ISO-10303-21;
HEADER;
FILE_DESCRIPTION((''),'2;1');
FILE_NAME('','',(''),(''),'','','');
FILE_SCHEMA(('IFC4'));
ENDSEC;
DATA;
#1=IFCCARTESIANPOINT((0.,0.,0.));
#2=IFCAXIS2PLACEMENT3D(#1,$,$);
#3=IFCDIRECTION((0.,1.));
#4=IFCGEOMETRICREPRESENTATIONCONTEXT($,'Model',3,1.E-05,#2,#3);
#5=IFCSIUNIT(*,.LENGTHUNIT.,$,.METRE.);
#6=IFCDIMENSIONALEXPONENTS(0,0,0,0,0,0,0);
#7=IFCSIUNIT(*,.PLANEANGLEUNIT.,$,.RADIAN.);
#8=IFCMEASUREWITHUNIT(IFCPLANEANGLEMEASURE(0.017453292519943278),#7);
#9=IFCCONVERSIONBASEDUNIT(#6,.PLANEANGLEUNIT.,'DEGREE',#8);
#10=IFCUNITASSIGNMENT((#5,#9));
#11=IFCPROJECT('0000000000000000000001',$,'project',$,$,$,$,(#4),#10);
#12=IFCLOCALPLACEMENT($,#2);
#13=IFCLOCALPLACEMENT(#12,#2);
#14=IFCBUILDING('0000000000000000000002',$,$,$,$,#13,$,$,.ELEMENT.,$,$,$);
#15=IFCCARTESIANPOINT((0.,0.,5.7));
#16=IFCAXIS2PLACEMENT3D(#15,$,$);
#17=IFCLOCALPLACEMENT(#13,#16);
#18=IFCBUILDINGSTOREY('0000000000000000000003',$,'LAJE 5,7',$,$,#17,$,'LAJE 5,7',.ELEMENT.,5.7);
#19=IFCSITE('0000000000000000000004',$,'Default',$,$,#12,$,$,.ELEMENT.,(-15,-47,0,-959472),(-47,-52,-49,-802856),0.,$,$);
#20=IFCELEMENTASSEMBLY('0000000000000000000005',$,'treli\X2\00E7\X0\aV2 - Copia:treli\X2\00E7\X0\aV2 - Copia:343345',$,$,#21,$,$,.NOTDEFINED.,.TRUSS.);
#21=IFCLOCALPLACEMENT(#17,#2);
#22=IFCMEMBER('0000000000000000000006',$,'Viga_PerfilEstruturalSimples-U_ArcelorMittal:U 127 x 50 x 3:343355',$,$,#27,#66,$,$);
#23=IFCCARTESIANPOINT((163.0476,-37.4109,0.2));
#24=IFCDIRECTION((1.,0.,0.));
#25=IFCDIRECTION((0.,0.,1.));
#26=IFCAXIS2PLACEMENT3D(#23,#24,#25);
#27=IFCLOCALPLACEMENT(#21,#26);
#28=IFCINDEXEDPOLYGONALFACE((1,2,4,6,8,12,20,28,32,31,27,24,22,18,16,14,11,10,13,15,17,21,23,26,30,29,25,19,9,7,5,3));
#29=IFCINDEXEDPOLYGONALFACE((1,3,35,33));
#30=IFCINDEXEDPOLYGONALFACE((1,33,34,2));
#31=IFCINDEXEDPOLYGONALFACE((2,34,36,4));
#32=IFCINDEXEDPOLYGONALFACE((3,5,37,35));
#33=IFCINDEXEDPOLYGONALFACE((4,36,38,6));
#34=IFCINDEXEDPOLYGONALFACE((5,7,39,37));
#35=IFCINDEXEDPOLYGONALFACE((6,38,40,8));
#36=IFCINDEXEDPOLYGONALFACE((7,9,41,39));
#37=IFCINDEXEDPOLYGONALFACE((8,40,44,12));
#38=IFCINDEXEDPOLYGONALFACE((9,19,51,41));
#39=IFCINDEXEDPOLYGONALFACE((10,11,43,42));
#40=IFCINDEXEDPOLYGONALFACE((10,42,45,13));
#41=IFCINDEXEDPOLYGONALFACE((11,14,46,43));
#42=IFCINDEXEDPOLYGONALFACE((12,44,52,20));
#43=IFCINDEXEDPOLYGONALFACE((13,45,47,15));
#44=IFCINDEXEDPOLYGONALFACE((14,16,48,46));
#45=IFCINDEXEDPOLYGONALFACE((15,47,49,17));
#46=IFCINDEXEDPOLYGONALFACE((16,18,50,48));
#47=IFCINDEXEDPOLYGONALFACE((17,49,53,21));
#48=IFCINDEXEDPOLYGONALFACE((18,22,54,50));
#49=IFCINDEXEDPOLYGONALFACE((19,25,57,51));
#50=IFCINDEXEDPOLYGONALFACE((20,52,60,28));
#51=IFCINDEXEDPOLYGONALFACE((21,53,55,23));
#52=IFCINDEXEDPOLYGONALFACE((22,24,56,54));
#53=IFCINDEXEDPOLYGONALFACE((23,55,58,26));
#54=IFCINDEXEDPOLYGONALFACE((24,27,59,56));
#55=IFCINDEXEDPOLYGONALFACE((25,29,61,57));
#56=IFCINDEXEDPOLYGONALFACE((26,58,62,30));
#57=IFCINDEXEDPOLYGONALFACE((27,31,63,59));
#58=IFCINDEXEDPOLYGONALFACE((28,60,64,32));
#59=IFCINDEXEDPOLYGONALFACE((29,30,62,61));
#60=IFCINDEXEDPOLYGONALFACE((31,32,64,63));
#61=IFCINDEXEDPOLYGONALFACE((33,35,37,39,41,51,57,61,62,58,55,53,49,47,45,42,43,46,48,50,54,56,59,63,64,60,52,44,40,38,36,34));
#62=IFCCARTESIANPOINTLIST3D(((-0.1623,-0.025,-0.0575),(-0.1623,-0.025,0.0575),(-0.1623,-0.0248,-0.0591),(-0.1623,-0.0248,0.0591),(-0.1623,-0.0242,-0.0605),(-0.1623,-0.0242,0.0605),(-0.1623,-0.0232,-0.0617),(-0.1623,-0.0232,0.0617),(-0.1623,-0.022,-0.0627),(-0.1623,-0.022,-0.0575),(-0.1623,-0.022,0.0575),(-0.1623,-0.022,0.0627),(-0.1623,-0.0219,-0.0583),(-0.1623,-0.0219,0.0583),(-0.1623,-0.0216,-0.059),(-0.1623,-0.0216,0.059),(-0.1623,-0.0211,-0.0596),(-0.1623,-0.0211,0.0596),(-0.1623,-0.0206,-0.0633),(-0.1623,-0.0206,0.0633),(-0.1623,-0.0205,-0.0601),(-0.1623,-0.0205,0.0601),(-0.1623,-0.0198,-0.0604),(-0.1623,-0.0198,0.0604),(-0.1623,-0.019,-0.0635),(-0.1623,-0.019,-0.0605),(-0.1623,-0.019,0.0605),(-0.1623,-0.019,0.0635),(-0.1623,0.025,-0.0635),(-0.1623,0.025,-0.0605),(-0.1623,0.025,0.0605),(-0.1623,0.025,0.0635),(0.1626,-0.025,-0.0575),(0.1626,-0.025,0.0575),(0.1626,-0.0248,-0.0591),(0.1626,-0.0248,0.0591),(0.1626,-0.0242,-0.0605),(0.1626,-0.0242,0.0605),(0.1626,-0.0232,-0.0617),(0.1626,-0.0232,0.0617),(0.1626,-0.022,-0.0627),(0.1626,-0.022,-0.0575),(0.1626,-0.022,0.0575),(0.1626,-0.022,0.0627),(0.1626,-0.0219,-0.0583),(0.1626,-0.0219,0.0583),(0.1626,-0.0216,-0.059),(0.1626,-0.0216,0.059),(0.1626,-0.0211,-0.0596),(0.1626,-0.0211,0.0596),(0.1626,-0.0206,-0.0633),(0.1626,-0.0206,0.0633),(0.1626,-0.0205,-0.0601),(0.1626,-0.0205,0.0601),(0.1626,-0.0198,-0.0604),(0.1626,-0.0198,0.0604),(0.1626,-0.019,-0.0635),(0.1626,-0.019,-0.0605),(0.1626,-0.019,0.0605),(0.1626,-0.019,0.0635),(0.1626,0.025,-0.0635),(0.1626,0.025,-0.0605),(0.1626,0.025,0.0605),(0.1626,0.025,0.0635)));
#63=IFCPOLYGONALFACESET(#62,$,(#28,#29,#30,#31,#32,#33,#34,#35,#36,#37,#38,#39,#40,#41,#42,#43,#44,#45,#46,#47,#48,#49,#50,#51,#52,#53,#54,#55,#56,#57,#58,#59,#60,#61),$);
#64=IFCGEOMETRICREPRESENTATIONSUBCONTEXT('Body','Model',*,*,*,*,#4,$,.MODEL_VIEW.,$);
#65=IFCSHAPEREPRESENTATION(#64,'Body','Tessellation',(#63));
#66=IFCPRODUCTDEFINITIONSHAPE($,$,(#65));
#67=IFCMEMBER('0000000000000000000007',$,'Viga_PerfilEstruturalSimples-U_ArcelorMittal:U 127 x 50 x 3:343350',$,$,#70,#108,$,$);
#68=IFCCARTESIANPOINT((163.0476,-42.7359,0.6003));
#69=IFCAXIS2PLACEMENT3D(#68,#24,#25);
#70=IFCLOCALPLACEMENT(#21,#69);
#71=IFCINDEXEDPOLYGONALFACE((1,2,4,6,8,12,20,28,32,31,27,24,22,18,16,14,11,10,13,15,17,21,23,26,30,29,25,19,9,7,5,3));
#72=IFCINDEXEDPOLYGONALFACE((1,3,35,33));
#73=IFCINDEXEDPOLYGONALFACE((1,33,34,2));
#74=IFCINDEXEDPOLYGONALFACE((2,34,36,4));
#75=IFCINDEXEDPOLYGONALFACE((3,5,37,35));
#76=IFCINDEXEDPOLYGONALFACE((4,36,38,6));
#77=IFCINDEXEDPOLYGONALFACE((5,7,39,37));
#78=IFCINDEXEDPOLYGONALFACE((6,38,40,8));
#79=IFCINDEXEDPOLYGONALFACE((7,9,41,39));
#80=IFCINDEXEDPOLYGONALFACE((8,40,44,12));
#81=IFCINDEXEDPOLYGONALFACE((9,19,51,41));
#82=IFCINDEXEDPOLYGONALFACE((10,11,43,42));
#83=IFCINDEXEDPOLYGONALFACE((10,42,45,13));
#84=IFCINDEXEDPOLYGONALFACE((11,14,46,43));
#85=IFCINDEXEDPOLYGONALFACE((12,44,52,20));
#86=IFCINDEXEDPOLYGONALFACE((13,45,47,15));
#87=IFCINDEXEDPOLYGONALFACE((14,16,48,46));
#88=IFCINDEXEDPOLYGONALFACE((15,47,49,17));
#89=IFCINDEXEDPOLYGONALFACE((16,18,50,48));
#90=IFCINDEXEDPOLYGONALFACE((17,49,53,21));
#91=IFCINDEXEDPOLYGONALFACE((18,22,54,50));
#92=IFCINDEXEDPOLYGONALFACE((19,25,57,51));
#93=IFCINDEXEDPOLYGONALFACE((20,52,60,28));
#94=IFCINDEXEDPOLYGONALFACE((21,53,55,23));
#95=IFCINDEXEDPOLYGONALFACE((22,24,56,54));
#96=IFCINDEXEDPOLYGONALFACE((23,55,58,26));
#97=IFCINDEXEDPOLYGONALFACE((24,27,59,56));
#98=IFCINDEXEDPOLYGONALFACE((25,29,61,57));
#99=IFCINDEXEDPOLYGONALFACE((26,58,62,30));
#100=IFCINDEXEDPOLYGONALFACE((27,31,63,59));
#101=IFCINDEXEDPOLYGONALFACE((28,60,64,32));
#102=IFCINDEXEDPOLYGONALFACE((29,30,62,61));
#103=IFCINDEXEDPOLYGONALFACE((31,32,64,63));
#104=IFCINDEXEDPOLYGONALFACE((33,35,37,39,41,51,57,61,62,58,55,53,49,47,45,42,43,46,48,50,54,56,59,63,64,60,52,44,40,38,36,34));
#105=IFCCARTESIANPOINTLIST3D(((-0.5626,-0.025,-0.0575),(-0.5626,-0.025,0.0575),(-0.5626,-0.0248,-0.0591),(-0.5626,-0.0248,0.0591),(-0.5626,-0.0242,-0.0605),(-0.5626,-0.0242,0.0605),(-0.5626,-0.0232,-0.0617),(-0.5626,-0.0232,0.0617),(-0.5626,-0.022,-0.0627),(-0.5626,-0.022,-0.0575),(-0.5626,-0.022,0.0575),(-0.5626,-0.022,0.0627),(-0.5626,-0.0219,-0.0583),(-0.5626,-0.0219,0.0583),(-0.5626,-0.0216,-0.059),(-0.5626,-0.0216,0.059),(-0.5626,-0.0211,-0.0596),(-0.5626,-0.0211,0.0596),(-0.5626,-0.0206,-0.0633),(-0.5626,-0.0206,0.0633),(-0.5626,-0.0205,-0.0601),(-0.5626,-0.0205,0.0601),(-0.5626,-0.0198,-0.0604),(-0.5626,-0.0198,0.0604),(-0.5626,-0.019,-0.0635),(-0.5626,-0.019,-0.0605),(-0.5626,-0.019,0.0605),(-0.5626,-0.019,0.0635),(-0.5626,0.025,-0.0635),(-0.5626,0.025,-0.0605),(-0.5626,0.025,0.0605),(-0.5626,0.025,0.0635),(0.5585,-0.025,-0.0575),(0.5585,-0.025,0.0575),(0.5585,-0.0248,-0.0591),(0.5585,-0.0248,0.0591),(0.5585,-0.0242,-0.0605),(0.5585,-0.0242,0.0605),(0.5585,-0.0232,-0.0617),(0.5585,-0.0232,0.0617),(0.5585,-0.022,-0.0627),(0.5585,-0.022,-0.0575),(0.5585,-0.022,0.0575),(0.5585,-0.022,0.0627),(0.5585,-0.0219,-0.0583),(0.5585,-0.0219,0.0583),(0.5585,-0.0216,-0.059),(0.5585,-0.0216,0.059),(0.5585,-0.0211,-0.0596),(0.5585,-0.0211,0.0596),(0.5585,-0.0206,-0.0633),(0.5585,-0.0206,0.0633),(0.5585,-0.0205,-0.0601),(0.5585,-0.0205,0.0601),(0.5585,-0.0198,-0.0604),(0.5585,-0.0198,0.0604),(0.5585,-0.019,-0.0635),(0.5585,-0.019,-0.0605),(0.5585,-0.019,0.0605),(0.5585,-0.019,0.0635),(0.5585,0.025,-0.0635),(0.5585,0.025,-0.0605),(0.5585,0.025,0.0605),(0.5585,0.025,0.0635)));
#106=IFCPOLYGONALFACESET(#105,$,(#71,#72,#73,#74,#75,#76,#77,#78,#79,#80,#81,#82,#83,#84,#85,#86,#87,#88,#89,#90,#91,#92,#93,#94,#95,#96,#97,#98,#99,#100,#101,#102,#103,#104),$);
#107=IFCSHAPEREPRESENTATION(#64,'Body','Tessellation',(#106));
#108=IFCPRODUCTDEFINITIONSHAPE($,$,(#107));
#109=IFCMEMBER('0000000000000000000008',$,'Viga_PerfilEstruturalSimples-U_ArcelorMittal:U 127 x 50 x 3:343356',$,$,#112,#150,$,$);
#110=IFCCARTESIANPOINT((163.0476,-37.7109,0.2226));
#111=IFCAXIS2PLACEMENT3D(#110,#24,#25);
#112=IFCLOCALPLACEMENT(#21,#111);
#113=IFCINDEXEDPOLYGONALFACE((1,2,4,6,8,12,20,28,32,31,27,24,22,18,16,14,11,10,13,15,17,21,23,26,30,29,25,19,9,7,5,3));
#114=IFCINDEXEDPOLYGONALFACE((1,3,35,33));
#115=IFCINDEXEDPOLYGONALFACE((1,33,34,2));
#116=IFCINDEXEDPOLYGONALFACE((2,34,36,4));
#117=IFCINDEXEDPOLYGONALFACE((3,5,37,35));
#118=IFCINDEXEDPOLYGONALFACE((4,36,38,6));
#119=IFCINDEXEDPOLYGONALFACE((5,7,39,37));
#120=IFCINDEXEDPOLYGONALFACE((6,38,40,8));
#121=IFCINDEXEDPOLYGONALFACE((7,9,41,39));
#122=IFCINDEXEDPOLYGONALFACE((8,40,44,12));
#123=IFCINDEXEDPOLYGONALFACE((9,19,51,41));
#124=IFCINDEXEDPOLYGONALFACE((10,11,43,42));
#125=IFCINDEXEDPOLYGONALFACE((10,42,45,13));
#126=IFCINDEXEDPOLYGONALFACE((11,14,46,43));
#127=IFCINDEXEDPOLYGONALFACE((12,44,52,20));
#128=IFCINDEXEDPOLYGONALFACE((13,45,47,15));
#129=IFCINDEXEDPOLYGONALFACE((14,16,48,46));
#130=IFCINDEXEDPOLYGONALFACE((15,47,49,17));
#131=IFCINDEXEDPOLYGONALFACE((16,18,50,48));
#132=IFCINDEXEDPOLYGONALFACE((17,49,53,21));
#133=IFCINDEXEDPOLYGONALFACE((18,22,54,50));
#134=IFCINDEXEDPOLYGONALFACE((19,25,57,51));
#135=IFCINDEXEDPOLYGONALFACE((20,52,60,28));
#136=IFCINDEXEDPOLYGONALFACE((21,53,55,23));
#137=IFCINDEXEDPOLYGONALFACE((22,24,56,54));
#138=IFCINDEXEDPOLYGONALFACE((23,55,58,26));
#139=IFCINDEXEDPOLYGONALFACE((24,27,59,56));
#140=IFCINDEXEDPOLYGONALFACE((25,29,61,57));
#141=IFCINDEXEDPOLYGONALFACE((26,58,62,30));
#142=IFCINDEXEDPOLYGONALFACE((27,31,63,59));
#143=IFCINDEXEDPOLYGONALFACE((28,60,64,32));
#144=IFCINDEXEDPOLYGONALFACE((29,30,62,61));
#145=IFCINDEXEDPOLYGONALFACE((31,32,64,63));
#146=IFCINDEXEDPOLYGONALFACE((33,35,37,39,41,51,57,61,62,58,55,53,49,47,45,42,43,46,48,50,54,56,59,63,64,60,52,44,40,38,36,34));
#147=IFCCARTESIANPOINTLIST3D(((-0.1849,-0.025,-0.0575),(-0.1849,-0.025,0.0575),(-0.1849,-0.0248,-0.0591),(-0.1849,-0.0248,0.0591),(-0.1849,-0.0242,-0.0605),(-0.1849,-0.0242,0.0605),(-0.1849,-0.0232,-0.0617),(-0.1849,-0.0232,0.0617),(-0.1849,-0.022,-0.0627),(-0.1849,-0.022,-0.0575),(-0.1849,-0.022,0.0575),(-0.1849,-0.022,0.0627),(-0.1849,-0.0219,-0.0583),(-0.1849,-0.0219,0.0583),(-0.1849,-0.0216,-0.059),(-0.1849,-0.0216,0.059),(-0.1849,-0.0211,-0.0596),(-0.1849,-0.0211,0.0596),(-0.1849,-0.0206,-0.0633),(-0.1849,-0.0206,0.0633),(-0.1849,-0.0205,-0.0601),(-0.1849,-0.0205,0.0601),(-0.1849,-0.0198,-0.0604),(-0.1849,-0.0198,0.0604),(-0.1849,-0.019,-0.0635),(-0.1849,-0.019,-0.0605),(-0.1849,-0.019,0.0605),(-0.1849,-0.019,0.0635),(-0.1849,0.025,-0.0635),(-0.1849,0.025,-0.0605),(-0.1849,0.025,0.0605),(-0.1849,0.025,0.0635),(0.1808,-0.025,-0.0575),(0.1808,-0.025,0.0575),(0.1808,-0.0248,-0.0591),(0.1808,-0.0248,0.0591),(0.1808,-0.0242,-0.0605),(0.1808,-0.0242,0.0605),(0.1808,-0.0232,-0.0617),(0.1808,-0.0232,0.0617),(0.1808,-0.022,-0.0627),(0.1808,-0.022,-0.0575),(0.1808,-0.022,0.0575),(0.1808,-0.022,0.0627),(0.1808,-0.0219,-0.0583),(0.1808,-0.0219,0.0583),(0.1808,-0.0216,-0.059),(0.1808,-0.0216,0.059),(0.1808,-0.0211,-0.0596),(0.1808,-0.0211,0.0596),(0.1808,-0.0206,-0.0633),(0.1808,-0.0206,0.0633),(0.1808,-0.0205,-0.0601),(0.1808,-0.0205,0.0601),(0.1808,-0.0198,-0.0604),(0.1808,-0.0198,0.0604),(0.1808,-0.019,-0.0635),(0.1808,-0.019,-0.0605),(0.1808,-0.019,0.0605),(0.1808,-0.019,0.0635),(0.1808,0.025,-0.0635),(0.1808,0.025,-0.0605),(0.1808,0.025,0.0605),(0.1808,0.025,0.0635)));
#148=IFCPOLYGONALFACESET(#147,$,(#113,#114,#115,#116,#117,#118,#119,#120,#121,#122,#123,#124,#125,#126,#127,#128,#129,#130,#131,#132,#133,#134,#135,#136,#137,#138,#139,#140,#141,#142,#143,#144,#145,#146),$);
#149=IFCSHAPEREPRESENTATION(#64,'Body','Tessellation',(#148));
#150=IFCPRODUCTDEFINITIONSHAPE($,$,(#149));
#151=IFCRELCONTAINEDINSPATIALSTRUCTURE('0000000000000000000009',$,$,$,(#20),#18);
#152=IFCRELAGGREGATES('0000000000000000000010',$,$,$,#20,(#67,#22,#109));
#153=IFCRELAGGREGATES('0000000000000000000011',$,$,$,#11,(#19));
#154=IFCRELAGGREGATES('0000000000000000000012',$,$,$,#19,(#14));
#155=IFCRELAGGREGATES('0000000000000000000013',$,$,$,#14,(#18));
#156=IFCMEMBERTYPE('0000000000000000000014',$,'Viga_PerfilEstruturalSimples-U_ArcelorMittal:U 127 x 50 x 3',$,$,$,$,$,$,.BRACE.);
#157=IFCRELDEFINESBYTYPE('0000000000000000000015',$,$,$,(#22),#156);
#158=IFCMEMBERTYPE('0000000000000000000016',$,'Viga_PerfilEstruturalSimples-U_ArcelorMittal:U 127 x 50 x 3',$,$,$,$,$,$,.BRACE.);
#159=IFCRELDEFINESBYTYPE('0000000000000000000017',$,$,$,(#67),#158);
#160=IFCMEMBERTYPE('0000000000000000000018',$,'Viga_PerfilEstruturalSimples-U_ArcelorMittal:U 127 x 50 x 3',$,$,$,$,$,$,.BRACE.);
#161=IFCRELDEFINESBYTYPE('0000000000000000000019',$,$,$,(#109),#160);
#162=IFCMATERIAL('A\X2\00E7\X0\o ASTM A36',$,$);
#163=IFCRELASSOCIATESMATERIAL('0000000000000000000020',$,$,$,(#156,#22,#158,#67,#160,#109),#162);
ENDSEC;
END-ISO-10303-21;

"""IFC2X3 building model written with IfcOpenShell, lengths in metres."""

from ifc_helpers import new_model, entity, si_unit, converted_unit, direction, frame, frame_2d, origin, place, context, subcontext, project, spatial, polyline, circle_curve, parameter, trimmed, segment, composite_curve, outline, extrude, source, transform, mapped, material, type_object, type_shapes, element, aggregate, save


model = new_model("IFC2X3")

# Units and contexts
model_context = context("Model", 3, precision=1e-05, world=origin(), true_north=direction((0.0, 1.0)))
body_context = subcontext(model_context, "Body", "Model", "MODEL_VIEW")
ifc_project = project(units=[si_unit("LENGTHUNIT", "METRE"), converted_unit("PLANEANGLEUNIT", "DEGREE", entity("IfcPlaneAngleMeasure", 0.017453292519943278), si_unit("PLANEANGLEUNIT", "RADIAN"), dimensions=[0, 0, 0, 0, 0, 0, 0])], contexts=[model_context])

# Site, building, storey
site_placement = place(None, origin())
site = spatial("IfcSite", under=ifc_project, at=site_placement, Name="Default", CompositionType="ELEMENT", RefLatitude=(-15, -47, 0, -959472), RefLongitude=(-47, -52, -49, -802856), RefElevation=0.0)
building_placement = place(site_placement, origin())
building = spatial("IfcBuilding", under=site, at=building_placement, CompositionType="ELEMENT")
storey_placement = place(building_placement, frame((0.0, 0.0, 5.7)))
storey = spatial("IfcBuildingStorey", under=building, at=storey_placement, Name="LAJE 5,7", LongName="LAJE 5,7", CompositionType="ELEMENT", Elevation=5.7)

# Element assembly
assembly_1_placement = place(storey_placement, origin())
assembly_1 = element("IfcElementAssembly", 1, at=assembly_1_placement, inside=storey, Name="treliçaV2 - Copia:treliçaV2 - Copia:343345", AssemblyPlace="NOTDEFINED", PredefinedType="TRUSS")
ifc_material = material(Name="Aço ASTM A36")
member_type_1 = type_object("IfcMemberType", Name="Viga_PerfilEstruturalSimples-U_ArcelorMittal:U 127 x 50 x 3", PredefinedType="BRACE", material=ifc_material)
shared_shape_1 = source(origin(), body_context, "Body", "SweptSolid", [
    extrude(outline(composite_curve([segment(polyline([(-0.0575, -0.0192), (0.0575, -0.0192)]), True, "CONTINUOUS"), segment(trimmed(circle_curve(frame_2d((0.0575, -0.0132), x_axis=(0.0, 1.0)), 0.006), [parameter(180.0)], [parameter(270.0)], True, "PARAMETER"), True, "CONTINUOUS"), segment(polyline([(0.0635, -0.0132), (0.0635, 0.0308)]), True, "CONTINUOUS"), segment(polyline([(0.0635, 0.0308), (0.0605, 0.0308)]), True, "CONTINUOUS"), segment(polyline([(0.0605, 0.0308), (0.0605, -0.0132)]), True, "CONTINUOUS"), segment(trimmed(circle_curve(frame_2d((0.0575, -0.0132), x_axis=(0.0, 1.0)), 0.003), [parameter(180.0)], [parameter(270.0)], True, "PARAMETER"), False, "CONTINUOUS"), segment(polyline([(0.0575, -0.0162), (-0.0575, -0.0162)]), True, "CONTINUOUS"), segment(trimmed(circle_curve(frame_2d((-0.0575, -0.0132), x_axis=(0.0, 1.0)), 0.003), [parameter(90.0)], [parameter(180.0)], True, "PARAMETER"), False, "CONTINUOUS"), segment(polyline([(-0.0605, -0.0132), (-0.0605, 0.0308)]), True, "CONTINUOUS"), segment(polyline([(-0.0605, 0.0308), (-0.0635, 0.0308)]), True, "CONTINUOUS"), segment(polyline([(-0.0635, 0.0308), (-0.0635, -0.0132)]), True, "CONTINUOUS"), segment(trimmed(circle_curve(frame_2d((-0.0575, -0.0132), x_axis=(0.0, 1.0)), 0.006), [parameter(90.0)], [parameter(180.0)], True, "PARAMETER"), True, "CONTINUOUS")], self_intersect=False)), frame((-0.1623, -0.0058, 0.0), z_axis=(1.0, 0.0, 0.0), x_axis=(0.0, 0.0, -1.0)), (0.0, 0.0, 1.0), 0.3249),
])
type_shapes(member_type_1, [shared_shape_1])

# Members
member_1_placement = place(assembly_1_placement, frame((163.0476, -37.4109, 0.2), z_axis=(1.0, 0.0, 0.0), x_axis=(0.0, 0.0, 1.0)))
member_1 = element("IfcMember", 2, at=member_1_placement, type_object=member_type_1, material=ifc_material, Name="Viga_PerfilEstruturalSimples-U_ArcelorMittal:U 127 x 50 x 3:343355", context=body_context, shape_type="MappedRepresentation", body=[
    mapped(shared_shape_1, transform((0.0, 0.0, 0.0), scale=1.0)),
])
member_type_2 = type_object("IfcMemberType", Name="Viga_PerfilEstruturalSimples-U_ArcelorMittal:U 127 x 50 x 3", PredefinedType="BRACE", material=ifc_material)
shared_shape_2 = source(origin(), body_context, "Body", "SweptSolid", [
    extrude(outline(composite_curve([segment(polyline([(-0.0575, -0.0192), (0.0575, -0.0192)]), True, "CONTINUOUS"), segment(trimmed(circle_curve(frame_2d((0.0575, -0.0132), x_axis=(0.0, 1.0)), 0.006), [parameter(180.0)], [parameter(270.0)], True, "PARAMETER"), True, "CONTINUOUS"), segment(polyline([(0.0635, -0.0132), (0.0635, 0.0308)]), True, "CONTINUOUS"), segment(polyline([(0.0635, 0.0308), (0.0605, 0.0308)]), True, "CONTINUOUS"), segment(polyline([(0.0605, 0.0308), (0.0605, -0.0132)]), True, "CONTINUOUS"), segment(trimmed(circle_curve(frame_2d((0.0575, -0.0132), x_axis=(0.0, 1.0)), 0.003), [parameter(180.0)], [parameter(270.0)], True, "PARAMETER"), False, "CONTINUOUS"), segment(polyline([(0.0575, -0.0162), (-0.0575, -0.0162)]), True, "CONTINUOUS"), segment(trimmed(circle_curve(frame_2d((-0.0575, -0.0132), x_axis=(0.0, 1.0)), 0.003), [parameter(90.0)], [parameter(180.0)], True, "PARAMETER"), False, "CONTINUOUS"), segment(polyline([(-0.0605, -0.0132), (-0.0605, 0.0308)]), True, "CONTINUOUS"), segment(polyline([(-0.0605, 0.0308), (-0.0635, 0.0308)]), True, "CONTINUOUS"), segment(polyline([(-0.0635, 0.0308), (-0.0635, -0.0132)]), True, "CONTINUOUS"), segment(trimmed(circle_curve(frame_2d((-0.0575, -0.0132), x_axis=(0.0, 1.0)), 0.006), [parameter(90.0)], [parameter(180.0)], True, "PARAMETER"), True, "CONTINUOUS")], self_intersect=False)), frame((-0.5626, -0.0058, 0.0), z_axis=(1.0, 0.0, 0.0), x_axis=(0.0, 0.0, -1.0)), (0.0, 0.0, 1.0), 1.1211),
])
type_shapes(member_type_2, [shared_shape_2])
member_2_placement = place(assembly_1_placement, frame((163.0476, -42.7359, 0.6003), z_axis=(1.0, 0.0, 0.0), x_axis=(0.0, 0.0, 1.0)))
member_2 = element("IfcMember", 3, at=member_2_placement, type_object=member_type_2, material=ifc_material, Name="Viga_PerfilEstruturalSimples-U_ArcelorMittal:U 127 x 50 x 3:343350", context=body_context, shape_type="MappedRepresentation", body=[
    mapped(shared_shape_2, transform((0.0, 0.0, 0.0), scale=1.0)),
])
member_type_3 = type_object("IfcMemberType", Name="Viga_PerfilEstruturalSimples-U_ArcelorMittal:U 127 x 50 x 3", PredefinedType="BRACE", material=ifc_material)
shared_shape_3 = source(origin(), body_context, "Body", "SweptSolid", [
    extrude(outline(composite_curve([segment(polyline([(-0.0575, -0.0192), (0.0575, -0.0192)]), True, "CONTINUOUS"), segment(trimmed(circle_curve(frame_2d((0.0575, -0.0132), x_axis=(0.0, 1.0)), 0.006), [parameter(180.0)], [parameter(270.0)], True, "PARAMETER"), True, "CONTINUOUS"), segment(polyline([(0.0635, -0.0132), (0.0635, 0.0308)]), True, "CONTINUOUS"), segment(polyline([(0.0635, 0.0308), (0.0605, 0.0308)]), True, "CONTINUOUS"), segment(polyline([(0.0605, 0.0308), (0.0605, -0.0132)]), True, "CONTINUOUS"), segment(trimmed(circle_curve(frame_2d((0.0575, -0.0132), x_axis=(0.0, 1.0)), 0.003), [parameter(180.0)], [parameter(270.0)], True, "PARAMETER"), False, "CONTINUOUS"), segment(polyline([(0.0575, -0.0162), (-0.0575, -0.0162)]), True, "CONTINUOUS"), segment(trimmed(circle_curve(frame_2d((-0.0575, -0.0132), x_axis=(0.0, 1.0)), 0.003), [parameter(90.0)], [parameter(180.0)], True, "PARAMETER"), False, "CONTINUOUS"), segment(polyline([(-0.0605, -0.0132), (-0.0605, 0.0308)]), True, "CONTINUOUS"), segment(polyline([(-0.0605, 0.0308), (-0.0635, 0.0308)]), True, "CONTINUOUS"), segment(polyline([(-0.0635, 0.0308), (-0.0635, -0.0132)]), True, "CONTINUOUS"), segment(trimmed(circle_curve(frame_2d((-0.0575, -0.0132), x_axis=(0.0, 1.0)), 0.006), [parameter(90.0)], [parameter(180.0)], True, "PARAMETER"), True, "CONTINUOUS")], self_intersect=False)), frame((-0.1849, -0.0058, 0.0), z_axis=(1.0, 0.0, 0.0), x_axis=(0.0, 0.0, -1.0)), (0.0, 0.0, 1.0), 0.3657),
])
type_shapes(member_type_3, [shared_shape_3])
member_3_placement = place(assembly_1_placement, frame((163.0476, -37.7109, 0.2226), z_axis=(1.0, 0.0, 0.0), x_axis=(0.0, 0.0, 1.0)))
member_3 = element("IfcMember", 4, at=member_3_placement, type_object=member_type_3, material=ifc_material, Name="Viga_PerfilEstruturalSimples-U_ArcelorMittal:U 127 x 50 x 3:343356", context=body_context, shape_type="MappedRepresentation", body=[
    mapped(shared_shape_3, transform((0.0, 0.0, 0.0), scale=1.0)),
])
aggregate(assembly_1, [member_2, member_1, member_3])

save(model, "model.ifc")
